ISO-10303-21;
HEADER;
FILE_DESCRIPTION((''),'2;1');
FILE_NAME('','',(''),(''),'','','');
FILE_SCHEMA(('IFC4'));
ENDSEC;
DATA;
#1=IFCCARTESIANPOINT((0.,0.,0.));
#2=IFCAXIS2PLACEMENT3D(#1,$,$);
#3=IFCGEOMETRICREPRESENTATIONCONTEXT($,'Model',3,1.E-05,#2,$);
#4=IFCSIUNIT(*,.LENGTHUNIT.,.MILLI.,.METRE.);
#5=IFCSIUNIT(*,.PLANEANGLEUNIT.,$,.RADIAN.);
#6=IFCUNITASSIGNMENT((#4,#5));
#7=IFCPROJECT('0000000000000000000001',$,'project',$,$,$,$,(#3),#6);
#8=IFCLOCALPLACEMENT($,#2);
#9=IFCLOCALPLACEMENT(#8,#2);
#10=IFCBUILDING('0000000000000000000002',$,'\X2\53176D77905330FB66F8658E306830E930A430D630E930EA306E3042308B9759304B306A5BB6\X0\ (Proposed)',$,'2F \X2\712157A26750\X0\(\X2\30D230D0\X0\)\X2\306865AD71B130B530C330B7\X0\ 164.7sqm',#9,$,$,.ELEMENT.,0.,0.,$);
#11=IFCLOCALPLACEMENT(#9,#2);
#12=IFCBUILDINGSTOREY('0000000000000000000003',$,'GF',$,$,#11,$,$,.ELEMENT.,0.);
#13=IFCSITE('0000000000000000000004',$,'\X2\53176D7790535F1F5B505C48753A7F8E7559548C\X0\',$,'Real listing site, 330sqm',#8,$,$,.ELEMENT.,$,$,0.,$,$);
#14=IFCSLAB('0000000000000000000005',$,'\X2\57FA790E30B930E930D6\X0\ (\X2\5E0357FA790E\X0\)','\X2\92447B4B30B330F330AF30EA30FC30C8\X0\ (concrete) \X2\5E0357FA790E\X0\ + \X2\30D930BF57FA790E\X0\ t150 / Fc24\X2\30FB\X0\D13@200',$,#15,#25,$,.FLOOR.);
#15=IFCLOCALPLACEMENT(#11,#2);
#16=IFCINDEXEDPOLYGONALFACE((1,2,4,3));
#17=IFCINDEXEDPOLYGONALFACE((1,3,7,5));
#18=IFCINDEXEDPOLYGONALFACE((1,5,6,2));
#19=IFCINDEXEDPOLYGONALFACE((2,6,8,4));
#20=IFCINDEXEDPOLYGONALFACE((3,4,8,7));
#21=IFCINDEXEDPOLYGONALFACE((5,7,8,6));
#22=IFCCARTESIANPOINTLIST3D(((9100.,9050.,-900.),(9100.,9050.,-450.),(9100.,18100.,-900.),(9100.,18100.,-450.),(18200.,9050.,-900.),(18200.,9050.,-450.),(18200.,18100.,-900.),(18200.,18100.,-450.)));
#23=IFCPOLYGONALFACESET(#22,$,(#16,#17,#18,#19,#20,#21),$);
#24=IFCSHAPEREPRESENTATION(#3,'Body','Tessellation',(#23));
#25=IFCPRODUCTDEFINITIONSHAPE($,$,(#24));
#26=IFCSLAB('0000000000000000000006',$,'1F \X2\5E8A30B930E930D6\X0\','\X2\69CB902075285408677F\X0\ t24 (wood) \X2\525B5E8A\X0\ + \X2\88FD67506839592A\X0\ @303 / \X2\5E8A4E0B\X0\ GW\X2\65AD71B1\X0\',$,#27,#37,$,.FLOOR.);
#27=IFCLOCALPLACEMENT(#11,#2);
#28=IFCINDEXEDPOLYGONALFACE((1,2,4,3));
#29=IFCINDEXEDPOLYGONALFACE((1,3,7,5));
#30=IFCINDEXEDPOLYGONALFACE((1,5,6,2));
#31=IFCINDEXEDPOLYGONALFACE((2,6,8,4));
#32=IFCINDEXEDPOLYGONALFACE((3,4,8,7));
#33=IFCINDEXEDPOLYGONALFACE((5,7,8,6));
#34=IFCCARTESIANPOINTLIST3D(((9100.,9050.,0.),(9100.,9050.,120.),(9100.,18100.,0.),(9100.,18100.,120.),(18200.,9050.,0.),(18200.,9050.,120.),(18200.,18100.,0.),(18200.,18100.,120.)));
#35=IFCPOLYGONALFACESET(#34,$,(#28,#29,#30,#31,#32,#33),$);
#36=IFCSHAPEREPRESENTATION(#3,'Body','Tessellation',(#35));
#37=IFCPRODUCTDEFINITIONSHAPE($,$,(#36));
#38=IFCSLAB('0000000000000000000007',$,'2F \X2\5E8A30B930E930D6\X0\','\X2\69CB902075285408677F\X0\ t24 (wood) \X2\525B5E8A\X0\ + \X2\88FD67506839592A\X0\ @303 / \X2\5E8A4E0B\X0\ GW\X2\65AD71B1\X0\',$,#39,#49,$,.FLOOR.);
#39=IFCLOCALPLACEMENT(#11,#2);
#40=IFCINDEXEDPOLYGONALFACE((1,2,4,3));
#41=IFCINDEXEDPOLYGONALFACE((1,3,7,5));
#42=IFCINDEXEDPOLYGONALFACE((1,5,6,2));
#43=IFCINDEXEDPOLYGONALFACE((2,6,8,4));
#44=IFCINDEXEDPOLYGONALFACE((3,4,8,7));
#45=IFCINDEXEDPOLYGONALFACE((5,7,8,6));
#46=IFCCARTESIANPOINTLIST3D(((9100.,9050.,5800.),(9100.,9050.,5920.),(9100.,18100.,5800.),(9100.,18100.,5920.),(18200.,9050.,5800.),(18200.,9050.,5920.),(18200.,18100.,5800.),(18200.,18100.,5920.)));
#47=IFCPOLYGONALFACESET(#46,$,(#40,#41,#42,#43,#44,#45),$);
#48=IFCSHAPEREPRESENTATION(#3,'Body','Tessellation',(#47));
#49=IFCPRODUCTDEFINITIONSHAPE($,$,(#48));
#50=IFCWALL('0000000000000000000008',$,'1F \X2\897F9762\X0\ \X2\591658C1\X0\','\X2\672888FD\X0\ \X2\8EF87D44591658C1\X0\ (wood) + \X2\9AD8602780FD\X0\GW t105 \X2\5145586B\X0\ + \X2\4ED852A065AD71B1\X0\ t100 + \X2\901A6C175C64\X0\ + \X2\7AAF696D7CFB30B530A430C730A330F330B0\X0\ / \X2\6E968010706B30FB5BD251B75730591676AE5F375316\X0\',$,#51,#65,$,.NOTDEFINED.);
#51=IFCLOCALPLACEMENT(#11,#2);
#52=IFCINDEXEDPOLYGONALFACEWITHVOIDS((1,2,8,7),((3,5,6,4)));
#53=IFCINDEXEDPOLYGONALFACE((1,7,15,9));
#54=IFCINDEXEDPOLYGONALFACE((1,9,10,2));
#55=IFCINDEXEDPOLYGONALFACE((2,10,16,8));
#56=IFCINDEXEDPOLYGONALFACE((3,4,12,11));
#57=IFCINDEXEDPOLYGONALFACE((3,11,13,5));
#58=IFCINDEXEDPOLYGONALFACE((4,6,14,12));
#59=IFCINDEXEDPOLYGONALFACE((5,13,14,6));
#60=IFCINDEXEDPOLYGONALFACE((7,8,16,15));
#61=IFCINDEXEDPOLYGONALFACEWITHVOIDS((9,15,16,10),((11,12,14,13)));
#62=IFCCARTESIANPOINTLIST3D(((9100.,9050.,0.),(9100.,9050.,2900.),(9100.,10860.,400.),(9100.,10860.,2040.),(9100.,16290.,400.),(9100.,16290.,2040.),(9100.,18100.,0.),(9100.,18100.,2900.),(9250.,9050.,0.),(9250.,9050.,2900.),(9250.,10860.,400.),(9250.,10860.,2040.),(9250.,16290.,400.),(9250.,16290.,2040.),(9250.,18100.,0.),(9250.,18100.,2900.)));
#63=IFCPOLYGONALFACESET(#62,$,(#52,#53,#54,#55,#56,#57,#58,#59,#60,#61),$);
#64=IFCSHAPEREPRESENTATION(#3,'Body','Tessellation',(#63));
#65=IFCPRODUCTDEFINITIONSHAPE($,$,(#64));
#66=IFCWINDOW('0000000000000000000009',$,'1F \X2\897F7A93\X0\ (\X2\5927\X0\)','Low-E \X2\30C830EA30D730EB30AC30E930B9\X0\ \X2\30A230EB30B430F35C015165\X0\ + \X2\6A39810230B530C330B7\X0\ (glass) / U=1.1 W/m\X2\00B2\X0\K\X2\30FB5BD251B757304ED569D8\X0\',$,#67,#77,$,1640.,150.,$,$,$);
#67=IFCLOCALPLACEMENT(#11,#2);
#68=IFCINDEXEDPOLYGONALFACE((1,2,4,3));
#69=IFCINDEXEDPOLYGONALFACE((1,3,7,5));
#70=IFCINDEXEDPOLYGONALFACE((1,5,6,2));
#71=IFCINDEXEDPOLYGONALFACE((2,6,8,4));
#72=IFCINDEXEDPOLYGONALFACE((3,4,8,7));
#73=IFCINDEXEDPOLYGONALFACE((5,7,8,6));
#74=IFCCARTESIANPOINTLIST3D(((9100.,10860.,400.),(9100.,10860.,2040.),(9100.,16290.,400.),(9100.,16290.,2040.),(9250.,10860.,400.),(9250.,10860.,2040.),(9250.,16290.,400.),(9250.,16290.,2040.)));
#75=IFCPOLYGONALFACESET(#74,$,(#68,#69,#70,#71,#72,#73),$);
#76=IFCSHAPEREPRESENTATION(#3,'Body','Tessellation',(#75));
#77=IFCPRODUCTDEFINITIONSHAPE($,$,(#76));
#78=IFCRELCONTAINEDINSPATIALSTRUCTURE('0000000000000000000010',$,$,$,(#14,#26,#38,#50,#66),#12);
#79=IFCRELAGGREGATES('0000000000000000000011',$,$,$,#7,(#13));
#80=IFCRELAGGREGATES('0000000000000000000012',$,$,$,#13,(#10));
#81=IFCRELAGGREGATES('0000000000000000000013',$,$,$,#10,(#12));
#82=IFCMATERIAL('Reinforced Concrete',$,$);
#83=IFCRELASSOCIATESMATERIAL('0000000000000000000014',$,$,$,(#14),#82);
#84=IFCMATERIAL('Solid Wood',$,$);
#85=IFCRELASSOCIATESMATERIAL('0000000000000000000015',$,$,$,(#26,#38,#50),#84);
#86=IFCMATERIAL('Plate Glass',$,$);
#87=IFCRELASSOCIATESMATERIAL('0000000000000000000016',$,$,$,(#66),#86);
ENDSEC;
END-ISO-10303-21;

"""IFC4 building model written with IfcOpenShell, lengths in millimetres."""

from ifc_helpers import new_model, si_unit, frame, frame_2d, origin, place, context, project, spatial, rectangle, extrude, material, element, fill, save


model = new_model("IFC4")

# Units and contexts
model_context = context("Model", 3, precision=1e-05, world=origin())
ifc_project = project(units=[si_unit("LENGTHUNIT", "METRE", prefix="MILLI"), si_unit("PLANEANGLEUNIT", "RADIAN")], contexts=[model_context])

# Site, building, storey
site_placement = place(None, origin())
site = spatial("IfcSite", under=ifc_project, at=site_placement, Name="北海道弟子屈町美留和", ObjectType="Real listing site, 330sqm", CompositionType="ELEMENT", RefElevation=0.0)
building_placement = place(site_placement, origin())
building = spatial("IfcBuilding", under=site, at=building_placement, Name="北海道・書斎とライブラリのある静かな家 (Proposed)", ObjectType="2F 無垢材(ヒバ)と断熱サッシ 164.7sqm", CompositionType="ELEMENT", ElevationOfRefHeight=0.0, ElevationOfTerrain=0.0)
storey_placement = place(building_placement, origin())
storey = spatial("IfcBuildingStorey", under=building, at=storey_placement, Name="GF", CompositionType="ELEMENT", Elevation=0.0)

# Shared definitions
ifc_material_1 = material(Name="Solid Wood")

# Slabs
ifc_material_2 = material(Name="Reinforced Concrete")
slab_1_placement = place(storey_placement, frame((4550.0, 4525.0, -450.0)))
element("IfcSlab", 1, at=slab_1_placement, inside=storey, material=ifc_material_2, Name="基礎スラブ (布基礎)", Description="鉄筋コンクリート (concrete) 布基礎 + ベタ基礎 t150 / Fc24・D13@200", PredefinedType="FLOOR", context=model_context, shape_type="SweptSolid", body=[
    extrude(rectangle(XDim=9100.0, YDim=9050.0, at=frame_2d((4550.0, 4525.0))), frame((4550.0, 4525.0, -450.0)), (0.0, 0.0, 1.0), 450.0),
])
slab_2_placement = place(storey_placement, frame((4550.0, 4525.0, 0.0)))
element("IfcSlab", 2, at=slab_2_placement, inside=storey, material=ifc_material_1, Name="1F 床スラブ", Description="構造用合板 t24 (wood) 剛床 + 製材根太 @303 / 床下 GW断熱", PredefinedType="FLOOR", context=model_context, shape_type="SweptSolid", body=[
    extrude(rectangle(XDim=9100.0, YDim=9050.0, at=frame_2d((4550.0, 4525.0))), frame((4550.0, 4525.0, 0.0)), (0.0, 0.0, 1.0), 120.0),
])
slab_3_placement = place(storey_placement, frame((4550.0, 4525.0, 2900.0)))
element("IfcSlab", 3, at=slab_3_placement, inside=storey, material=ifc_material_1, Name="2F 床スラブ", Description="構造用合板 t24 (wood) 剛床 + 製材根太 @303 / 床下 GW断熱", PredefinedType="FLOOR", context=model_context, shape_type="SweptSolid", body=[
    extrude(rectangle(XDim=9100.0, YDim=9050.0, at=frame_2d((4550.0, 4525.0))), frame((4550.0, 4525.0, 2900.0)), (0.0, 0.0, 1.0), 120.0),
])

# Shared definitions
ifc_material_3 = material(Name="Plate Glass")

# Wall, opening, window
wall_1_placement = place(storey_placement, frame((4550.0, 4525.0, 0.0)))
wall_1 = element("IfcWall", 4, at=wall_1_placement, inside=storey, material=ifc_material_1, Name="1F 西面 外壁", Description="木製 軸組外壁 (wood) + 高性能GW t105 充填 + 付加断熱 t100 + 通気層 + 窯業系サイディング / 準耐火・寒冷地外皮強化", PredefinedType="NOTDEFINED", context=model_context, shape_type="SweptSolid", body=[
    extrude(rectangle(XDim=150.0, YDim=9050.0, at=frame_2d((75.0, 4525.0))), frame((4550.0, 4525.0, 0.0)), (0.0, 0.0, 1.0), 2900.0),
])
opening_1_placement = place(storey_placement, frame((4550.0, 5430.0, 200.0)))
opening_1 = element("IfcOpeningElement", 5, at=opening_1_placement, cuts=wall_1, PredefinedType="NOTDEFINED", context=model_context, shape_type="SweptSolid", body=[
    extrude(rectangle(XDim=150.0, YDim=5430.0, at=frame_2d((75.0, 2715.0))), frame((4550.0, 5430.0, 200.0)), (0.0, 0.0, 1.0), 1640.0),
])
window_1_placement = place(storey_placement, frame((4550.0, 5430.0, 200.0)))
window_1 = element("IfcWindow", 6, at=window_1_placement, inside=storey, material=ifc_material_3, Name="1F 西窓 (大)", Description="Low-E トリプルガラス アルゴン封入 + 樹脂サッシ (glass) / U=1.1 W/m²K・寒冷地仕様", OverallHeight=1640.0, OverallWidth=150.0, context=model_context, shape_type="SweptSolid", body=[
    extrude(rectangle(XDim=150.0, YDim=5430.0, at=frame_2d((75.0, 2715.0))), frame((4550.0, 5430.0, 200.0)), (0.0, 0.0, 1.0), 1640.0),
])
fill(opening_1, window_1)

save(model, "model.ifc")
